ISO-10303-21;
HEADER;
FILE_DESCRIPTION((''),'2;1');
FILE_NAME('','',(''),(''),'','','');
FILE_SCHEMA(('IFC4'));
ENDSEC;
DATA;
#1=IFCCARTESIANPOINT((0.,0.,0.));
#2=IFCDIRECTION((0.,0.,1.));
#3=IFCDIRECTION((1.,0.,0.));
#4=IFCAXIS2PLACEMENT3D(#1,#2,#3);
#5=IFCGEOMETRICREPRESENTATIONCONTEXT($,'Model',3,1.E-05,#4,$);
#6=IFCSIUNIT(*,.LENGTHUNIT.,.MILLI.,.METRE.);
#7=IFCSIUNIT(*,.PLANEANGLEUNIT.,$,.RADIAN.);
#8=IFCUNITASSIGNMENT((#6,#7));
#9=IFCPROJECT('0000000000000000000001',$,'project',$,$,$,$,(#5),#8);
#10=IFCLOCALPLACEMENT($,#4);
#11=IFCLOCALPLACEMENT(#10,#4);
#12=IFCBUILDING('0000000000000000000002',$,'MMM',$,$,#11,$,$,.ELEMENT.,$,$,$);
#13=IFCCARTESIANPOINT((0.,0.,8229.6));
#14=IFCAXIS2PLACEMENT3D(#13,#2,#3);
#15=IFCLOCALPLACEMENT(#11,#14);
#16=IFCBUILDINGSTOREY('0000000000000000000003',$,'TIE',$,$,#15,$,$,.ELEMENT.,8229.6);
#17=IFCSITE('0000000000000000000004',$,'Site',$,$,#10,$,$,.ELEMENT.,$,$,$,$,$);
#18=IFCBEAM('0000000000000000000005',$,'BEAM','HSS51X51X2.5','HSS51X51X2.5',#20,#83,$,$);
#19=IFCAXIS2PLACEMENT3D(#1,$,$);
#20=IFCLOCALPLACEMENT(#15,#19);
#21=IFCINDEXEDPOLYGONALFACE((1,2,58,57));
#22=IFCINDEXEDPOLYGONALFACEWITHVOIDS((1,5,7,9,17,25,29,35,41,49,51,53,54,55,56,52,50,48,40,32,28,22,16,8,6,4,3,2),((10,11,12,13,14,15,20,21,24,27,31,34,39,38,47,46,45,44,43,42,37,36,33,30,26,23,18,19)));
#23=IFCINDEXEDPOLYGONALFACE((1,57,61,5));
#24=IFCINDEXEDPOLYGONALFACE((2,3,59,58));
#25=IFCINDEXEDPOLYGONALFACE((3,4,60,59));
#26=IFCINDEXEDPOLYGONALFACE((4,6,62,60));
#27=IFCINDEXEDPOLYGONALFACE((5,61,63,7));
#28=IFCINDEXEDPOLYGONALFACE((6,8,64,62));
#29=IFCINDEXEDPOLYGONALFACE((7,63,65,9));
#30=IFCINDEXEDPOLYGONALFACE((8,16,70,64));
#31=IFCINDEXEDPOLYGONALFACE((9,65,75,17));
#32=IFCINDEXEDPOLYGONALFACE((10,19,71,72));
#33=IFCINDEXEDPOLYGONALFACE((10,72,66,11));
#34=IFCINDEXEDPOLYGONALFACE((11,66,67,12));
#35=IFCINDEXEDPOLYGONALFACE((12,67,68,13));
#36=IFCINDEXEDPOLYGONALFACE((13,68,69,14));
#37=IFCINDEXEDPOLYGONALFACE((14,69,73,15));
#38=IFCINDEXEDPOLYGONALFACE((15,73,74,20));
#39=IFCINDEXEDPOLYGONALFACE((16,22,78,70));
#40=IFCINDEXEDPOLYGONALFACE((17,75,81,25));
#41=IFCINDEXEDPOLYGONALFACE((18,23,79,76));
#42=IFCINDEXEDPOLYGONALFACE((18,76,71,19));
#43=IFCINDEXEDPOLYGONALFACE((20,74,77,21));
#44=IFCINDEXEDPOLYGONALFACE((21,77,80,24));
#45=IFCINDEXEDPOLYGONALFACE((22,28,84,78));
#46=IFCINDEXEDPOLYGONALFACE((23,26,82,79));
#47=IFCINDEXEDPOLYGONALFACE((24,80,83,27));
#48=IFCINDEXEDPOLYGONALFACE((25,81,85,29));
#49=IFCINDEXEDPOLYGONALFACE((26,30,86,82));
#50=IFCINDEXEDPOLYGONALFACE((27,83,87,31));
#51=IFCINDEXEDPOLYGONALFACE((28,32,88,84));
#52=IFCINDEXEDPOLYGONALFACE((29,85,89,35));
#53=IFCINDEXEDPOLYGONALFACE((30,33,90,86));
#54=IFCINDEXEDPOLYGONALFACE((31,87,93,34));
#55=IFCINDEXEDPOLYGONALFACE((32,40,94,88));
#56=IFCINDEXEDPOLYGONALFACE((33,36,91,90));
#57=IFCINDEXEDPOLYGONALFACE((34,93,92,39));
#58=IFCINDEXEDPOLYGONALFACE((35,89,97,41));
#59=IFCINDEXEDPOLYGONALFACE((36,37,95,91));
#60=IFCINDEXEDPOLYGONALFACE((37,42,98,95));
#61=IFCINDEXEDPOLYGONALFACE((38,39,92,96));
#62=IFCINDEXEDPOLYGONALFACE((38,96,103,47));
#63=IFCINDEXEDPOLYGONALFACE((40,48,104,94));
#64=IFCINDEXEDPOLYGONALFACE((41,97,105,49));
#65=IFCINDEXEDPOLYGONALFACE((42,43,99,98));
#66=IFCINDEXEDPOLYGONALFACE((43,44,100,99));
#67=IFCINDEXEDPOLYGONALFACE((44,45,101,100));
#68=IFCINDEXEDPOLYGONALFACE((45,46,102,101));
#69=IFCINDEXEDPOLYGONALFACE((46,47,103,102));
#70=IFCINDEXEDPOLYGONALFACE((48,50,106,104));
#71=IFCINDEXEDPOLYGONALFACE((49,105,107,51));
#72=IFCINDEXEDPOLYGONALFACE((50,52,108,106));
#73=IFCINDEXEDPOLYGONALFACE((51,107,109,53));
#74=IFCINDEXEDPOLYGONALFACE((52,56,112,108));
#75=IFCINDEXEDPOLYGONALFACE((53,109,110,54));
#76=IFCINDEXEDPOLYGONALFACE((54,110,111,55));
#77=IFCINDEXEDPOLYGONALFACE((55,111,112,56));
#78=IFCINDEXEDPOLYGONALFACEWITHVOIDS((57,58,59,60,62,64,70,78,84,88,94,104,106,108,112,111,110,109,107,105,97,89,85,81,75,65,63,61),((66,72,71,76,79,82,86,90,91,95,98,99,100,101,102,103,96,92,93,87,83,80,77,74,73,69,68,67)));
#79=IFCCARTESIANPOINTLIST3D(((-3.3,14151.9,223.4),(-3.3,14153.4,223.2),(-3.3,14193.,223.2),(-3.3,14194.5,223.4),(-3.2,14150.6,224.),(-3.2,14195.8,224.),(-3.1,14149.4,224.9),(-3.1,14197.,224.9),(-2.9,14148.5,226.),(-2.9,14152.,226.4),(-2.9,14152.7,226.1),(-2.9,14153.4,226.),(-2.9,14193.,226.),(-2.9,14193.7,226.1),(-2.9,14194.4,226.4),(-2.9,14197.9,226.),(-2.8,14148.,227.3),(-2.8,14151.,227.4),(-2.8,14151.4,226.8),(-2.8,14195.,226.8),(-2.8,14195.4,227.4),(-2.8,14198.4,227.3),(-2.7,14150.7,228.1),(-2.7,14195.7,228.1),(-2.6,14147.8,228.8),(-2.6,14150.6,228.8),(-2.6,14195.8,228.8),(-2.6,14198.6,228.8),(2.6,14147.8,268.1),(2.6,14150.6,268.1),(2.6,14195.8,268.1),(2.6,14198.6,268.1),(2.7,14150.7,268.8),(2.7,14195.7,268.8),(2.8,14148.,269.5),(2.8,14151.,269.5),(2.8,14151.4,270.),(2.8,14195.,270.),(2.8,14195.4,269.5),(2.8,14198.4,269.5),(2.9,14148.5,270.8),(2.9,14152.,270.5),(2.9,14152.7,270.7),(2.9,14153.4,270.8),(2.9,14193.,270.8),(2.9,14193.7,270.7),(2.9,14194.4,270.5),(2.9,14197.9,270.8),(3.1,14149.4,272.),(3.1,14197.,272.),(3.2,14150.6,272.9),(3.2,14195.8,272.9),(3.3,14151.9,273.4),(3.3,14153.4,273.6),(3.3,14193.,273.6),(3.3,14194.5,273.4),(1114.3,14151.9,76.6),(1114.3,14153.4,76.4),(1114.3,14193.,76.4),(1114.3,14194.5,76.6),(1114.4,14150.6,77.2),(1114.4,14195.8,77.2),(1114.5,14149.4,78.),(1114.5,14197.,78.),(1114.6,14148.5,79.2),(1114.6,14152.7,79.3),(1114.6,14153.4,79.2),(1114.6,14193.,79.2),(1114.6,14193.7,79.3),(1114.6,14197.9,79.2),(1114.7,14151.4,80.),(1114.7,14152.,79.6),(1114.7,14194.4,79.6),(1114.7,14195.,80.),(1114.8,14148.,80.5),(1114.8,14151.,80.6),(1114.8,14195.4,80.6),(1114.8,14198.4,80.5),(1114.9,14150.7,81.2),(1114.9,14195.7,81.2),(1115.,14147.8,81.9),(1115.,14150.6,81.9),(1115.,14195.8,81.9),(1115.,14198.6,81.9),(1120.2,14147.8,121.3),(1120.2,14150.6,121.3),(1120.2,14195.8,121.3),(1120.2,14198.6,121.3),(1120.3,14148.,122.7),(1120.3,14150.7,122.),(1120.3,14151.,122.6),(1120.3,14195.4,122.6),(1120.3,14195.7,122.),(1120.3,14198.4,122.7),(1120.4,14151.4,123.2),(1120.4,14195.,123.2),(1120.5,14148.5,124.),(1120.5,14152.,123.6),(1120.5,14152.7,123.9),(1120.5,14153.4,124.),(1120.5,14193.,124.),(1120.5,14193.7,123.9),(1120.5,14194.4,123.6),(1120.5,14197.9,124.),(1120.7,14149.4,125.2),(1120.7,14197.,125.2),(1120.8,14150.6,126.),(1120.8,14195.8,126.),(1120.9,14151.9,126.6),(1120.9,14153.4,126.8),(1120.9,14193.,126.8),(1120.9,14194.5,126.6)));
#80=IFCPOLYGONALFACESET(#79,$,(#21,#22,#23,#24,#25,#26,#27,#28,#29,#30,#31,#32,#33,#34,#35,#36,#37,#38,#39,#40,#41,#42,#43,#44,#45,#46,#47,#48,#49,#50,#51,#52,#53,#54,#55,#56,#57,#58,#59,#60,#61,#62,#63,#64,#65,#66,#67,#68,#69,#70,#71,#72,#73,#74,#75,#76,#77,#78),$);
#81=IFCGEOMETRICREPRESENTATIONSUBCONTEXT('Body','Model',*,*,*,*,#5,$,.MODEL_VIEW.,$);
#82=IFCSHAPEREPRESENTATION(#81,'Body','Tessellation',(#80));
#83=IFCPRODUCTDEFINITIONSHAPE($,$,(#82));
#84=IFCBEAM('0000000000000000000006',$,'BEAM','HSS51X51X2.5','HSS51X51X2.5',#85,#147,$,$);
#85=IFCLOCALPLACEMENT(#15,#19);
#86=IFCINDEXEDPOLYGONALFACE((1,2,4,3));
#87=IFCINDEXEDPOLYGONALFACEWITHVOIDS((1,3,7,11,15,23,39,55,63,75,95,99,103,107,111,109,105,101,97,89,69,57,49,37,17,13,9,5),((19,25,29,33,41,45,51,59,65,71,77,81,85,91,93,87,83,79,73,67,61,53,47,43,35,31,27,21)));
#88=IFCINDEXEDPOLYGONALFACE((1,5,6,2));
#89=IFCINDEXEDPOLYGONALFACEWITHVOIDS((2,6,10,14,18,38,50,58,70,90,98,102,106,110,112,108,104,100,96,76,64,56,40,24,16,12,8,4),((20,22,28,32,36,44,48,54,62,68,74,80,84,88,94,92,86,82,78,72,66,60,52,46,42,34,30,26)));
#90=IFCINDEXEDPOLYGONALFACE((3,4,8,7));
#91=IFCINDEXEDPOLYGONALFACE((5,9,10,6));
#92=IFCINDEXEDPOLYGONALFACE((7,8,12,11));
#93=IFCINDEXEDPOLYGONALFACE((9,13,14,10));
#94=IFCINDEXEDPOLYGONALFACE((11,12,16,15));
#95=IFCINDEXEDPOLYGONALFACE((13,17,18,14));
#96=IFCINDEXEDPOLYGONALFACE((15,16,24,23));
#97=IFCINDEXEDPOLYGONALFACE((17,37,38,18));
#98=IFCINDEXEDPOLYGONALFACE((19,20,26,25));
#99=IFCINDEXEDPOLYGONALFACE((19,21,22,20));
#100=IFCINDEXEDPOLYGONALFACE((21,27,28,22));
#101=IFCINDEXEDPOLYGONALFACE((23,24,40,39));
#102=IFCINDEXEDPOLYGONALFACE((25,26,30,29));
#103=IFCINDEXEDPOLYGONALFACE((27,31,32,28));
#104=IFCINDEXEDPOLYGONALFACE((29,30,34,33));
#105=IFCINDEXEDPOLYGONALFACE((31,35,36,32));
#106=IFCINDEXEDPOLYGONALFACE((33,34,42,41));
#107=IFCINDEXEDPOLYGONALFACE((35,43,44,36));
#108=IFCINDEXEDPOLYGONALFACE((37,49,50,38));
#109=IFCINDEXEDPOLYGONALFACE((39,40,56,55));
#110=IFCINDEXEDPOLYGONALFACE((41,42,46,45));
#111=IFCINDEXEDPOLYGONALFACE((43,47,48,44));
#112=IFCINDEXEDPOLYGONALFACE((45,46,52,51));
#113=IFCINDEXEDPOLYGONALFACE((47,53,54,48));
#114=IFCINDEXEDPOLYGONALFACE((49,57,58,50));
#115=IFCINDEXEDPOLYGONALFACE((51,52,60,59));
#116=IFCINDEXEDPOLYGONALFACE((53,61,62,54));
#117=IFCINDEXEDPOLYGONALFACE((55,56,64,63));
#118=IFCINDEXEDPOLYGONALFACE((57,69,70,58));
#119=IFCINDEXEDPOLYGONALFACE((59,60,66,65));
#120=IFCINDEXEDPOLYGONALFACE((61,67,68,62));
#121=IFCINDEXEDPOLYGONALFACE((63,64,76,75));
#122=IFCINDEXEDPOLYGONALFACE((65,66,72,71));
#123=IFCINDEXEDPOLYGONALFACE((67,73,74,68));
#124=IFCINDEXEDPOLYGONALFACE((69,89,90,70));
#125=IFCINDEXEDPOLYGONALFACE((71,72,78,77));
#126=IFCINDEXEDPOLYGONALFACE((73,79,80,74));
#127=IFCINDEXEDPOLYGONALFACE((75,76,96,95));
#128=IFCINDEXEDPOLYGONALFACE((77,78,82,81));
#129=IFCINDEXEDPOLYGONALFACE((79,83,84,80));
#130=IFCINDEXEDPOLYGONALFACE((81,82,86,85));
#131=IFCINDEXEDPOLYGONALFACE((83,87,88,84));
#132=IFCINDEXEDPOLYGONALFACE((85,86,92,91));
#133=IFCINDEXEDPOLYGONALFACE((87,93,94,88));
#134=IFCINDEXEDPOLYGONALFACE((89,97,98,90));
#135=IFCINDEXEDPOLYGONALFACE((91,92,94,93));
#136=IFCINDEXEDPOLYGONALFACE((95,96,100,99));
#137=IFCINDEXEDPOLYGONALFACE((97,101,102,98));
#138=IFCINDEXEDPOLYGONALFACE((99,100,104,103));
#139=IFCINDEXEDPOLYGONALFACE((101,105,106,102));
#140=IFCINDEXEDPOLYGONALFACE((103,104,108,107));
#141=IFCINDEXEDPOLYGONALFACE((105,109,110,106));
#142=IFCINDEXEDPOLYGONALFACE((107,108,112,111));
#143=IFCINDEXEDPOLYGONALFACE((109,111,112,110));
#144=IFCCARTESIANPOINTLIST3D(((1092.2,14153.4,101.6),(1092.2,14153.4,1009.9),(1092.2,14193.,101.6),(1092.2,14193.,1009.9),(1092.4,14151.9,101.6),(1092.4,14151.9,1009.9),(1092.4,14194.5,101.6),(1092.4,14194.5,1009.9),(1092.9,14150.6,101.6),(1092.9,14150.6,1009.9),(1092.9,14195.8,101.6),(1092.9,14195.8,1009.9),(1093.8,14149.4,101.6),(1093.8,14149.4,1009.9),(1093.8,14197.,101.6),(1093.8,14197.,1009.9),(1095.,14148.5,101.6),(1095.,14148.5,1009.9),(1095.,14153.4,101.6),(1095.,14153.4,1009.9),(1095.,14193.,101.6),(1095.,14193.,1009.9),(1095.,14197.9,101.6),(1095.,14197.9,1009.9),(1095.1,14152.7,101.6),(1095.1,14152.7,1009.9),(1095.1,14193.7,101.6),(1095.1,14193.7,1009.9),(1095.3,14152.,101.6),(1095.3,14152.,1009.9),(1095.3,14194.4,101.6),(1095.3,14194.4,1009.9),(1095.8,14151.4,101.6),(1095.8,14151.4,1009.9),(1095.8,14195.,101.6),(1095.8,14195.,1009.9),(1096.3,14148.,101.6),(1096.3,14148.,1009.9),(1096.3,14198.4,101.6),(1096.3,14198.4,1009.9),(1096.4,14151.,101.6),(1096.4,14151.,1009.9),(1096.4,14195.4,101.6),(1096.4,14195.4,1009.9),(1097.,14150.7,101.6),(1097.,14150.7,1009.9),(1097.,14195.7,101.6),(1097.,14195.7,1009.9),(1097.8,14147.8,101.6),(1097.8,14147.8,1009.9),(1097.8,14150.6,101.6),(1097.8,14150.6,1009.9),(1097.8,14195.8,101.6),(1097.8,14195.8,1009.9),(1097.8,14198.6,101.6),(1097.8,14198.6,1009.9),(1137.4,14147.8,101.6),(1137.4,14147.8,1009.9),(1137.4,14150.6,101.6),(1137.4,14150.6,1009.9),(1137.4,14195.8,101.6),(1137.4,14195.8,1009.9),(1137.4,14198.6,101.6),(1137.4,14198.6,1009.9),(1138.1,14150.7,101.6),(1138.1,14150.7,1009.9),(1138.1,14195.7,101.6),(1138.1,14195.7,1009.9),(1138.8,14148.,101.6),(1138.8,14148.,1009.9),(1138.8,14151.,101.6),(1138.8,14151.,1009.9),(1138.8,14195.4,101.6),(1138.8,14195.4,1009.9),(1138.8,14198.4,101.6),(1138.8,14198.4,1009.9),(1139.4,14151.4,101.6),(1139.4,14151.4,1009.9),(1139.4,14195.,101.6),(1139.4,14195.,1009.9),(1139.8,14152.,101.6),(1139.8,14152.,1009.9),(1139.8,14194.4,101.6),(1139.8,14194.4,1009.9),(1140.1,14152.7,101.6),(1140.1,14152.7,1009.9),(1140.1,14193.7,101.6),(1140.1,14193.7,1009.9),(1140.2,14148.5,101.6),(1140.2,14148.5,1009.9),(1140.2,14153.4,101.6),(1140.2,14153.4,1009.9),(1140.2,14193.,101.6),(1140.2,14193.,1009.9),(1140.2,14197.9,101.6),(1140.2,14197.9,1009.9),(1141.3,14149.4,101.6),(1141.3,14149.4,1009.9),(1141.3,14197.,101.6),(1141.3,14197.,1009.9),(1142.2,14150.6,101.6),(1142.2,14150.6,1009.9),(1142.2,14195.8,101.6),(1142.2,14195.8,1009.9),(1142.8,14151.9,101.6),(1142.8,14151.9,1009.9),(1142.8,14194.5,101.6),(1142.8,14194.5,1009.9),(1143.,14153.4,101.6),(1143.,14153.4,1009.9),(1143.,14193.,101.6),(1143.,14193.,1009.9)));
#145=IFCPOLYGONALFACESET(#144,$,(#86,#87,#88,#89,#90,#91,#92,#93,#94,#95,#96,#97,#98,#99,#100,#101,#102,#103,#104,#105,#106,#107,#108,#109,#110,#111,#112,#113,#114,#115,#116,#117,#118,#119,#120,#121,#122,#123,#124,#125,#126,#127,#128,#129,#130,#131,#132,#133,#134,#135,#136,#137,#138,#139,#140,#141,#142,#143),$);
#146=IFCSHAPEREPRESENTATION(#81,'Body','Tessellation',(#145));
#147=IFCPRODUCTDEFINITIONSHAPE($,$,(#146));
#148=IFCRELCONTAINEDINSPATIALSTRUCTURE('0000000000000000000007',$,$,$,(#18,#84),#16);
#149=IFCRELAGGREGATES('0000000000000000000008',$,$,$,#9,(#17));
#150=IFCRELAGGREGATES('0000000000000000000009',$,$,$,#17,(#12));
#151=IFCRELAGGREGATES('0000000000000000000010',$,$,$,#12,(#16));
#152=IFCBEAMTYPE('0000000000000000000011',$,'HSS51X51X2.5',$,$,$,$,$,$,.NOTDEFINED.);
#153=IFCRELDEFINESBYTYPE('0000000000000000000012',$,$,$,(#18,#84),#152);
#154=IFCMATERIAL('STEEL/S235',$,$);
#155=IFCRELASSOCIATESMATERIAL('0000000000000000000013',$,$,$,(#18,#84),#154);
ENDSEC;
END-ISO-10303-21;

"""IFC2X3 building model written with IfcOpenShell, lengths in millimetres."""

from ifc_helpers import new_model, si_unit, frame, origin_with_axes, origin_2d_with_axis, place, context, subcontext, project, spatial, hollow_rectangle, extrude, material, type_object, element, save


model = new_model("IFC2X3")

# Units and contexts
model_context = context("Model", 3, precision=1e-05, world=origin_with_axes())
body_context = subcontext(model_context, "Body", "Model", "MODEL_VIEW")
ifc_project = project(units=[si_unit("LENGTHUNIT", "METRE", prefix="MILLI"), si_unit("PLANEANGLEUNIT", "RADIAN")], contexts=[model_context])

# Site, building, storey
site_placement = place(None, origin_with_axes())
site = spatial("IfcSite", under=ifc_project, at=site_placement, Name="Site", CompositionType="ELEMENT")
building_placement = place(site_placement, origin_with_axes())
building = spatial("IfcBuilding", under=site, at=building_placement, Name="MMM", CompositionType="ELEMENT")
storey_placement = place(building_placement, frame((0.0, 0.0, 8229.6), z_axis=(0.0, 0.0, 1.0), x_axis=(1.0, 0.0, 0.0)))
storey = spatial("IfcBuildingStorey", under=building, at=storey_placement, Name="TIE", CompositionType="ELEMENT", Elevation=8229.6)

# Beams
ifc_material = material(Name="STEEL/S235")
beam_type_1 = type_object("IfcBeamType", Name="HSS51X51X2.5", PredefinedType="NOTDEFINED")
beam_1_placement = place(storey_placement, frame((1117.6, 14173.2, 101.6), z_axis=(0.130258, 0.0, 0.99148), x_axis=(-0.99148, 0.0, 0.130258)))
element("IfcBeam", 1, at=beam_1_placement, inside=storey, type_object=beam_type_1, material=ifc_material, Name="BEAM", Description="HSS51X51X2.5", ObjectType="HSS51X51X2.5", context=body_context, shape_type="SweptSolid", body=[
    extrude(hollow_rectangle(XDim=50.8, YDim=50.8, WallThickness=2.8, InnerFilletRadius=2.8, OuterFilletRadius=5.6, at=origin_2d_with_axis()), frame((1127.2, 0.0, 0.0), z_axis=(-1.0, 0.0, 0.0), x_axis=(0.0, -1.0, 0.0)), (0.0, 0.0, 1.0), 1127.2),
])
beam_2_placement = place(storey_placement, frame((1117.6, 14173.2, 1009.9), z_axis=(1.0, 0.0, 0.0), x_axis=(0.0, 0.0, -1.0)))
element("IfcBeam", 2, at=beam_2_placement, inside=storey, type_object=beam_type_1, material=ifc_material, Name="BEAM", Description="HSS51X51X2.5", ObjectType="HSS51X51X2.5", context=body_context, shape_type="SweptSolid", body=[
    extrude(hollow_rectangle(XDim=50.8, YDim=50.8, WallThickness=2.8, InnerFilletRadius=2.8, OuterFilletRadius=5.6, at=origin_2d_with_axis()), frame((908.3, 0.0, 0.0), z_axis=(-1.0, 0.0, 0.0), x_axis=(0.0, -1.0, 0.0)), (0.0, 0.0, 1.0), 908.3),
])

save(model, "model.ifc")
